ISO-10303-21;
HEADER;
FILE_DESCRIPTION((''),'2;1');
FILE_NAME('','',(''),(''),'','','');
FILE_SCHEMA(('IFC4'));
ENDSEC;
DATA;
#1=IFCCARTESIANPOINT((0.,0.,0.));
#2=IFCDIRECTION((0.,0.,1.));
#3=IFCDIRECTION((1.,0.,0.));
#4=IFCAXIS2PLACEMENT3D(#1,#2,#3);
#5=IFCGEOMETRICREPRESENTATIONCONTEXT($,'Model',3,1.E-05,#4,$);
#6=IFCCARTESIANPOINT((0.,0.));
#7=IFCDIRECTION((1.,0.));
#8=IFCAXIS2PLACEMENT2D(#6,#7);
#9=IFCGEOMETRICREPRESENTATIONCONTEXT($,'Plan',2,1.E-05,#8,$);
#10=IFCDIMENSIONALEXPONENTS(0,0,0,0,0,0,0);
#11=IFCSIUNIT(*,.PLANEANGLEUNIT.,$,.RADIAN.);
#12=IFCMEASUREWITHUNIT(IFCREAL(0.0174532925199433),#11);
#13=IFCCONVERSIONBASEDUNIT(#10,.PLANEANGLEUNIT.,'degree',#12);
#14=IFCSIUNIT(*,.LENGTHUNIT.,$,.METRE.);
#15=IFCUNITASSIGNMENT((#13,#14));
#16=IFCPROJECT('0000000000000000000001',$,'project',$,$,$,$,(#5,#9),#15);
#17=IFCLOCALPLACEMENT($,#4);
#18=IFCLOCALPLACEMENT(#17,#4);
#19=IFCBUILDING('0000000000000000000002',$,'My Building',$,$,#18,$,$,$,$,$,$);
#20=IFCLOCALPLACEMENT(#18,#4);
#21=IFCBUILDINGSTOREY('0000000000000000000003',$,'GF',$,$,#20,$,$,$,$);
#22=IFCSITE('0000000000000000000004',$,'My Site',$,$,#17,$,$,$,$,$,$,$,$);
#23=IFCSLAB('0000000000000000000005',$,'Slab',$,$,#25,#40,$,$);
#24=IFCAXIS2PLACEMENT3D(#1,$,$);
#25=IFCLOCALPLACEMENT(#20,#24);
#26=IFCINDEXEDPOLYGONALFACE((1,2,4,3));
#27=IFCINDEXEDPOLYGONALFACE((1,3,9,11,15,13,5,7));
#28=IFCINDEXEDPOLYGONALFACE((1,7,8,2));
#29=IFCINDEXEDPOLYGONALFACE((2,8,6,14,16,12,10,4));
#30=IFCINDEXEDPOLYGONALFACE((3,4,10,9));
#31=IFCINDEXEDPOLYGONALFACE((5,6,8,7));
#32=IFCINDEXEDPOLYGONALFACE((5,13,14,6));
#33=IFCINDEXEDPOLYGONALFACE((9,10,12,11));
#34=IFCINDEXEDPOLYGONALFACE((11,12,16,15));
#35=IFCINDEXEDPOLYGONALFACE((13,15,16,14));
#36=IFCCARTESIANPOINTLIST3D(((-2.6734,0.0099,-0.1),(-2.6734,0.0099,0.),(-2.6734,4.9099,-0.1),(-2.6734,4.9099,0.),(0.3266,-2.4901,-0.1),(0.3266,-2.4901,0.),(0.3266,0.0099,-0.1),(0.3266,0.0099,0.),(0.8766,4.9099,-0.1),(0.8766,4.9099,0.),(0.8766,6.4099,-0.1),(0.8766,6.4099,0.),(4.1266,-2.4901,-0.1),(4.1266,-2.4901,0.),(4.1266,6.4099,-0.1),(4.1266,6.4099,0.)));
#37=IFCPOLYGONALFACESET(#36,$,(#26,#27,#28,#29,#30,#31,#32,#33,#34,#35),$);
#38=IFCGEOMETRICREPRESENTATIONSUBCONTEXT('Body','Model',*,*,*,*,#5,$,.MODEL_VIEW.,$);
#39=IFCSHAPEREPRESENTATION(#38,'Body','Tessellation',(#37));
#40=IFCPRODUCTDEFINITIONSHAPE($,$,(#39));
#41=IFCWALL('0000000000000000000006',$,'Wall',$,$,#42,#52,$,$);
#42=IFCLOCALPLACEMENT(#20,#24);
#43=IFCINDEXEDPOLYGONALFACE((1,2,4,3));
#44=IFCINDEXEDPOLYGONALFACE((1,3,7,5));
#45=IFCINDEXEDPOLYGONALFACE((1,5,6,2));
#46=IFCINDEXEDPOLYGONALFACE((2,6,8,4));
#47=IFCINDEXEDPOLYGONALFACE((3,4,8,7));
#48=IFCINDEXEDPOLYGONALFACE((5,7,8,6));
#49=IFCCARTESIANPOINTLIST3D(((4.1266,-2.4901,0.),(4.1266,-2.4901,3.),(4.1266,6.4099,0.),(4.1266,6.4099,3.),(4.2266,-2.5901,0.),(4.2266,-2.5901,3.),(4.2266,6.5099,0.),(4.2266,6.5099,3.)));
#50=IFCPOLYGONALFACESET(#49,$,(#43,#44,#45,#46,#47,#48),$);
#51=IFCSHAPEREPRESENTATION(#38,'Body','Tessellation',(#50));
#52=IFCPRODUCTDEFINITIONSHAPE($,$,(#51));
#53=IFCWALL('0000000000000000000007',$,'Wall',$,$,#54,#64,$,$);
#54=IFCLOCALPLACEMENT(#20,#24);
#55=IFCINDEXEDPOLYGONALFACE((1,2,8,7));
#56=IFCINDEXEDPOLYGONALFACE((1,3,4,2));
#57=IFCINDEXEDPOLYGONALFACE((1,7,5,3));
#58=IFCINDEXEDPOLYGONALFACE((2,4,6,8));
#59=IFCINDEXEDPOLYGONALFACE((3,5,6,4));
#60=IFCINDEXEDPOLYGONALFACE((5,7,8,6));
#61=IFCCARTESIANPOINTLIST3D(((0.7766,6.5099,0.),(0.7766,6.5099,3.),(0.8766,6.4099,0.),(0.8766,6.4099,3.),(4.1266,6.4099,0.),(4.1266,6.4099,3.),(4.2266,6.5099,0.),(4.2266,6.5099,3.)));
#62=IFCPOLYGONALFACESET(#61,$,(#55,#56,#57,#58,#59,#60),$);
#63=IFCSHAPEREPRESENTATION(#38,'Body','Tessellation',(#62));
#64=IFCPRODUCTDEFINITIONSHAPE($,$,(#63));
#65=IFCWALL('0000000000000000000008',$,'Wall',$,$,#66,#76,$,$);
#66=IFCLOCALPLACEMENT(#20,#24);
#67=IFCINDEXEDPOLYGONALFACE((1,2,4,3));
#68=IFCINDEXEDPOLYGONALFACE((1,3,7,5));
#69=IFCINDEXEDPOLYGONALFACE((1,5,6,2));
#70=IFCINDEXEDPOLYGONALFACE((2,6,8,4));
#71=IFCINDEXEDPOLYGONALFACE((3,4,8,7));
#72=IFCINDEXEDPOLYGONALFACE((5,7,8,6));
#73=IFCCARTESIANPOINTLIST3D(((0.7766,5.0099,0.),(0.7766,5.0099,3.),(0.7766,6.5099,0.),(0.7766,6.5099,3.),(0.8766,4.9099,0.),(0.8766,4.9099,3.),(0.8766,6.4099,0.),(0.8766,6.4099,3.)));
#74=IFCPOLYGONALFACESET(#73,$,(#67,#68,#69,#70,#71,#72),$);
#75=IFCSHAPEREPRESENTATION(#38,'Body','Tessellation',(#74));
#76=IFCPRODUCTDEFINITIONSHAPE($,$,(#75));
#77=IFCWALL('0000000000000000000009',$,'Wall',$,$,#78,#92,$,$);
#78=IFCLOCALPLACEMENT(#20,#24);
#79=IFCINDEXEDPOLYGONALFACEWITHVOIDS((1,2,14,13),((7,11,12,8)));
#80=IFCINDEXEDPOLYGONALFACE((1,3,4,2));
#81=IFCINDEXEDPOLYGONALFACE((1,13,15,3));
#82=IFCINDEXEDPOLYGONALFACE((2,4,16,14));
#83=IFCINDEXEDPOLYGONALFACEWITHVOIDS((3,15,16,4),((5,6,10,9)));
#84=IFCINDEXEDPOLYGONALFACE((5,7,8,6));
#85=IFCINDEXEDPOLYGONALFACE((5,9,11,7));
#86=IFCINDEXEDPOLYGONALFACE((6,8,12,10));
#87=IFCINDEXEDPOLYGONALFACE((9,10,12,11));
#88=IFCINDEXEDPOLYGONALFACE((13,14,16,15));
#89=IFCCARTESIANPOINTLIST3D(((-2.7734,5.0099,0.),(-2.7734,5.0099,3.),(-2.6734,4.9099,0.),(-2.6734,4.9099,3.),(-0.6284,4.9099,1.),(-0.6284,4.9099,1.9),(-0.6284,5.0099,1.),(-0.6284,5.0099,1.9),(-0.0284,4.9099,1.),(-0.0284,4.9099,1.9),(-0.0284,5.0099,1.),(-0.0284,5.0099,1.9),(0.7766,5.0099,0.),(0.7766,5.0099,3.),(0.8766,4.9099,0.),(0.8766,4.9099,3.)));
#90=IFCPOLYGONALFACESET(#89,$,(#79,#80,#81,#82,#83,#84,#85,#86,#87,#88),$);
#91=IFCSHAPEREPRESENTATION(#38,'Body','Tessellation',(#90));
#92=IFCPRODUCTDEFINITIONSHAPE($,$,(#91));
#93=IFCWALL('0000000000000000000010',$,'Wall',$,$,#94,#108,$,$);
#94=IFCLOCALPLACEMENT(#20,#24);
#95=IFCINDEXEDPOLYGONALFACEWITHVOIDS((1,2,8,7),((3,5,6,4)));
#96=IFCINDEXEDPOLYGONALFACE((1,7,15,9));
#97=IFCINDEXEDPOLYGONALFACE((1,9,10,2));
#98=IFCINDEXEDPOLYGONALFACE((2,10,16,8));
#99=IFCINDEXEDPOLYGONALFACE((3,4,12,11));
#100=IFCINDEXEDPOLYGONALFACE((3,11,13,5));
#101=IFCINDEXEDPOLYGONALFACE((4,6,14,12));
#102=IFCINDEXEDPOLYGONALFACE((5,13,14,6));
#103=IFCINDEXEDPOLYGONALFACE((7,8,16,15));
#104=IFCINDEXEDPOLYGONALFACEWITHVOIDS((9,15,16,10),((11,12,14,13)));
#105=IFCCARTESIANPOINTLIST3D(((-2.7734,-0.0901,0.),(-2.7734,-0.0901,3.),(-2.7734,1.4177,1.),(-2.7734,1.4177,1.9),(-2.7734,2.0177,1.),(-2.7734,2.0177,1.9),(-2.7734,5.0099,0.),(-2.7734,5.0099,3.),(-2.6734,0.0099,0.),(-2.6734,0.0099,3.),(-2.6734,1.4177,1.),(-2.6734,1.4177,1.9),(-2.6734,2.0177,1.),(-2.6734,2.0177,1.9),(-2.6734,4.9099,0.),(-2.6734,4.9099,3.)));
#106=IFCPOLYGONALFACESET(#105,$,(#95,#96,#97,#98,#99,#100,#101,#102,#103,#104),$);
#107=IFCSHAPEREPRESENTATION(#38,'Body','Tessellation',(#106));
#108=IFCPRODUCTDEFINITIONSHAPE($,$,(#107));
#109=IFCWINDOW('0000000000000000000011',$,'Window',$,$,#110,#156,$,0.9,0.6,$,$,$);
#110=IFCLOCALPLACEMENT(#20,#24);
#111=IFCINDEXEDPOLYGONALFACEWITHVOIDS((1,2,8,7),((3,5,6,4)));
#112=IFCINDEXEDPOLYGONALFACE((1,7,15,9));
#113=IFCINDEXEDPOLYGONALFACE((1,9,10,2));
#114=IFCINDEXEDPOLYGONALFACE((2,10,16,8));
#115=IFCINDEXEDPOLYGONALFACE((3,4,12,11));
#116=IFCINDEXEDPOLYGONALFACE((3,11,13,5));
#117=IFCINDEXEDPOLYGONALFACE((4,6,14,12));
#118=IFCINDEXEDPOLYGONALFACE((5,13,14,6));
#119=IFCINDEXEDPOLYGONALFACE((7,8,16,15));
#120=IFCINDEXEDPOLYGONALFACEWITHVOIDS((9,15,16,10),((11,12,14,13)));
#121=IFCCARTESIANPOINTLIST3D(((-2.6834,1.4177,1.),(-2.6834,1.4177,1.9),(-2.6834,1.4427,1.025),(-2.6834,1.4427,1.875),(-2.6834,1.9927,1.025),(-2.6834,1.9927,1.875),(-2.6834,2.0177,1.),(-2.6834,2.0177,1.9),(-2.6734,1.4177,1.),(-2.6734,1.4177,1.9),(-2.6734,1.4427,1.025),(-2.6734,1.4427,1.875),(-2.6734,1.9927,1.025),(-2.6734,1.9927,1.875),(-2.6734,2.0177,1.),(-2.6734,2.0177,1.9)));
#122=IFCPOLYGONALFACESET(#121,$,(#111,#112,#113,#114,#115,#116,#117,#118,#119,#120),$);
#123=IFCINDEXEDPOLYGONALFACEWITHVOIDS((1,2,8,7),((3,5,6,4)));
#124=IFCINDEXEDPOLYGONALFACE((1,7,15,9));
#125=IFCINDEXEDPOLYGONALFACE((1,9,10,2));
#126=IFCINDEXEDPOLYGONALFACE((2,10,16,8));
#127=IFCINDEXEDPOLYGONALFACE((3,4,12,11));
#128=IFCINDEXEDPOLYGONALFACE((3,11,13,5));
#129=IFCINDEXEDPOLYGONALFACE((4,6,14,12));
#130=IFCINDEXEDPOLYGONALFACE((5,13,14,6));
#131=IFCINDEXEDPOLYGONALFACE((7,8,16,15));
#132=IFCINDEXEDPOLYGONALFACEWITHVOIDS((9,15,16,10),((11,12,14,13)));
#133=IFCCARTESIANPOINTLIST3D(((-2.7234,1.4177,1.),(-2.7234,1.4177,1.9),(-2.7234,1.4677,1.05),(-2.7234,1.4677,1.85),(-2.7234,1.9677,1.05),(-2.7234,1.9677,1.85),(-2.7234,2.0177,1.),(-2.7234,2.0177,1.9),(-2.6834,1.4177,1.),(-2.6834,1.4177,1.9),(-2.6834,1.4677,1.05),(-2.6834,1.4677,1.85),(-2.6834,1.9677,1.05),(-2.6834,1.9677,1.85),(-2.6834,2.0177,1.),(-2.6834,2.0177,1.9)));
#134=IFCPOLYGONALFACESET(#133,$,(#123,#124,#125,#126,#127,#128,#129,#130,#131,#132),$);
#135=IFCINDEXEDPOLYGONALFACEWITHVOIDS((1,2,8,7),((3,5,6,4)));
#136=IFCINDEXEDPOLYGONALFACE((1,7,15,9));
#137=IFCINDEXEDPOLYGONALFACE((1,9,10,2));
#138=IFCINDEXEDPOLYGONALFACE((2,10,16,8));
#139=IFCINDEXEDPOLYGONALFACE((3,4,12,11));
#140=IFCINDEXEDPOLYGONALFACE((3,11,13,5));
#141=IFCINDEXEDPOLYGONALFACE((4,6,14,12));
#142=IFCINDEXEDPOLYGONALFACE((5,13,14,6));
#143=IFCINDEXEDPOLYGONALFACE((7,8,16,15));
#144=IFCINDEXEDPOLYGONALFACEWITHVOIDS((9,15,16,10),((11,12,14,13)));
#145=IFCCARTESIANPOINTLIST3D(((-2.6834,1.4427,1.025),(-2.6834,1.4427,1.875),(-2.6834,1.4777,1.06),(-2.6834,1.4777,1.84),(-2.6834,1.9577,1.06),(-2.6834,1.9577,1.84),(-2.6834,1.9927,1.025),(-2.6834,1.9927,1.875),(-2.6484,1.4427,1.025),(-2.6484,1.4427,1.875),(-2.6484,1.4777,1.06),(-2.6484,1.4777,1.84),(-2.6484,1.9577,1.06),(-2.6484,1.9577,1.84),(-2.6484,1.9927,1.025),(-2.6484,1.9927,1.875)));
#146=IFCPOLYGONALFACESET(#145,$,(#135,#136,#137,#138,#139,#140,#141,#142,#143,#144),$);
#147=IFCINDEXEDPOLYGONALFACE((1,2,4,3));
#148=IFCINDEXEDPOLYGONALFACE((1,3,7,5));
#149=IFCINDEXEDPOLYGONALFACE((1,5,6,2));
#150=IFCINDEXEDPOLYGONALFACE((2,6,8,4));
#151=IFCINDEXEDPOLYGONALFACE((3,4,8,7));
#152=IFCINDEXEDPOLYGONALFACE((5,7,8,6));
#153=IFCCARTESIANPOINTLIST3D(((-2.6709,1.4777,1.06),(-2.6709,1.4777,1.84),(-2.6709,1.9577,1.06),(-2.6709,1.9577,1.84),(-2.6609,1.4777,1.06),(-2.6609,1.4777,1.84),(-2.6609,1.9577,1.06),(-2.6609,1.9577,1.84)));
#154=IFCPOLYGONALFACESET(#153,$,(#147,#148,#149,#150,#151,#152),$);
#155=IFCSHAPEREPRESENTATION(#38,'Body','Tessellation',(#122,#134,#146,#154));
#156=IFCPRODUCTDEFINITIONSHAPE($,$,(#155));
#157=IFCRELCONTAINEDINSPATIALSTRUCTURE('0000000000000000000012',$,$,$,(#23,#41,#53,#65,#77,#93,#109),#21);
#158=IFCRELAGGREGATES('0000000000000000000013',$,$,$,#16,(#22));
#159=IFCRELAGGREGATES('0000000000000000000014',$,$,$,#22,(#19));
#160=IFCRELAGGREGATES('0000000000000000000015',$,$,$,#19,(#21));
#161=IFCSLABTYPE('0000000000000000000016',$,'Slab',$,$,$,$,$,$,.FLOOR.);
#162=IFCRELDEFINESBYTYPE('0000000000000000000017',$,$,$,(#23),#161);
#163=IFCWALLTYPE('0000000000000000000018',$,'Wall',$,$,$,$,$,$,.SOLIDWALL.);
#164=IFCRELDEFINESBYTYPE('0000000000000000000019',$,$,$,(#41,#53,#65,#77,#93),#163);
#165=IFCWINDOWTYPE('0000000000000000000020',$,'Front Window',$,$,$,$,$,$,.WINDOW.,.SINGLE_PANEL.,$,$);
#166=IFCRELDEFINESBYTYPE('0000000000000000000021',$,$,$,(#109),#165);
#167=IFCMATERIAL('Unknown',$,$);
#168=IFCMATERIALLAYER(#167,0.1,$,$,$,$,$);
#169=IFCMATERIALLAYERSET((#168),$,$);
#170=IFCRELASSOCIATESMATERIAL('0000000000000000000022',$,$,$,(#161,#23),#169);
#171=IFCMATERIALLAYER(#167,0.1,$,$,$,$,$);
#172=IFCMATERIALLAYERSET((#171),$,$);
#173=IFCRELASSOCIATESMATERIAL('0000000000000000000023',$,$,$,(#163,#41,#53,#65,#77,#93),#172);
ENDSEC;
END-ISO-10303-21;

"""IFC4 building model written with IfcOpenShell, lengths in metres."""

from ifc_helpers import new_model, entity, si_unit, converted_unit, frame, origin_with_axes, origin_2d_with_axis, place, context, subcontext, project, spatial, line, indexed_curve, outline, extrude, shape, source, transform, mapped, material, layer, layer_set, layer_usage, type_object, type_shapes, element, fill, save


model = new_model("IFC4")

# Units and contexts
model_context = context("Model", 3, precision=1e-05, world=origin_with_axes())
plan_context = context("Plan", 2, precision=1e-05, world=origin_2d_with_axis())
body_context_1 = subcontext(model_context, "Body", "Model", "MODEL_VIEW")
body_context_2 = subcontext(plan_context, "Body", "Plan", "PLAN_VIEW")
ifc_project = project(units=[converted_unit("PLANEANGLEUNIT", "degree", entity("IfcReal", 0.0174532925199433), si_unit("PLANEANGLEUNIT", "RADIAN"), dimensions=[0, 0, 0, 0, 0, 0, 0]), si_unit("LENGTHUNIT", "METRE")], contexts=[model_context, plan_context])

# Site, building, storey
site_placement = place(None, origin_with_axes())
site = spatial("IfcSite", under=ifc_project, at=site_placement, Name="My Site")
building_placement = place(site_placement, origin_with_axes())
building = spatial("IfcBuilding", under=site, at=building_placement, Name="My Building")
storey_placement = place(building_placement, origin_with_axes())
storey = spatial("IfcBuildingStorey", under=building, at=storey_placement, Name="GF")

# Slab
ifc_material = material(Name="Unknown")
ifc_layer_1 = layer(ifc_material, 0.1)
ifc_layer_set_1 = layer_set([ifc_layer_1])
ifc_layer_usage_1 = layer_usage(ifc_layer_set_1, "AXIS3", "POSITIVE", -0.1)
slab_type = type_object("IfcSlabType", Name="Slab", PredefinedType="FLOOR", material=ifc_layer_set_1)
slab_placement = place(storey_placement, frame((4.1266, 6.4099, 0.0), z_axis=(0.0, 0.0, 1.0), x_axis=(1.0, 0.0, 0.0)))
element("IfcSlab", 1, at=slab_placement, inside=storey, type_object=slab_type, material=ifc_layer_usage_1, Name="Slab", context=body_context_1, shape_type="SweptSolid", body=[
    extrude(outline(indexed_curve([(0.0, 0.0), (-3.25, 0.0), (-3.25, -1.5), (-6.8, -1.5), (-6.8, -6.4), (-3.8, -6.4), (-3.8, -8.9), (0.0, -8.9), (0.0, 0.0)])), frame((0.0, 0.0, -0.1), z_axis=(0.0, 0.0, 1.0), x_axis=(1.0, 0.0, 0.0)), (0.0, 0.0, 1.0), 0.1),
])

# Shared definitions
ifc_layer_2 = layer(ifc_material, 0.1)
ifc_layer_set_2 = layer_set([ifc_layer_2])
wall_type = type_object("IfcWallType", Name="Wall", PredefinedType="SOLIDWALL", material=ifc_layer_set_2)
shared_shape_1 = source(origin_with_axes(), body_context_1, "Body", "SweptSolid", [
    extrude(outline(indexed_curve([(0.0, 0.0), (0.6, 0.0), (0.6, 0.9), (0.0, 0.9)], segments=[line(1, 2, 3, 4, 1)])), frame((0.0, -0.6, 0.0), z_axis=(0.0, -1.0, 0.0), x_axis=(1.0, 0.0, 0.0)), (0.0, 0.0, -1.0), 1.2),
])
window_type_1 = type_object("IfcWindowType", Name="Front Window", PartitioningType="SINGLE_PANEL", PredefinedType="WINDOW")
shared_shape_2 = source(origin_with_axes(), body_context_1, "Body", "SweptSolid", [
    extrude(outline(indexed_curve([(0.0, 0.0), (0.6, 0.0), (0.6, 0.9), (0.0, 0.9)], segments=[line(1, 2, 3, 4, 1)]), holes=[indexed_curve([(0.025, 0.025), (0.575, 0.025), (0.575, 0.875), (0.025, 0.875)], segments=[line(1, 2, 3, 4, 1)])]), frame((0.0, 0.09, 0.0), z_axis=(0.0, -1.0, 0.0), x_axis=(1.0, 0.0, 0.0)), (0.0, 0.0, -1.0), 0.01),
    extrude(outline(indexed_curve([(0.0, 0.0), (0.6, 0.0), (0.6, 0.9), (0.0, 0.9)], segments=[line(1, 2, 3, 4, 1)]), holes=[indexed_curve([(0.05, 0.05), (0.55, 0.05), (0.55, 0.85), (0.05, 0.85)], segments=[line(1, 2, 3, 4, 1)])]), frame((0.0, 0.05, 0.0), z_axis=(0.0, -1.0, 0.0), x_axis=(1.0, 0.0, 0.0)), (0.0, 0.0, -1.0), 0.04),
    extrude(outline(indexed_curve([(0.0, 0.0), (0.55, 0.0), (0.55, 0.85), (0.0, 0.85)], segments=[line(1, 2, 3, 4, 1)]), holes=[indexed_curve([(0.035, 0.035), (0.515, 0.035), (0.515, 0.815), (0.035, 0.815)], segments=[line(1, 2, 3, 4, 1)])]), frame((0.025, 0.09, 0.025), z_axis=(0.0, -1.0, 0.0), x_axis=(1.0, 0.0, 0.0)), (0.0, 0.0, -1.0), 0.035),
    extrude(outline(indexed_curve([(0.035, 0.035), (0.515, 0.035), (0.515, 0.815), (0.035, 0.815)], segments=[line(1, 2, 3, 4, 1)])), frame((0.025, 0.1025, 0.025), z_axis=(0.0, -1.0, 0.0), x_axis=(1.0, 0.0, 0.0)), (0.0, 0.0, -1.0), 0.01),
])
shared_shape_3 = source(origin_with_axes(), body_context_2, "Body", "Curve2D", [
    entity("IfcIndexedPolyCurve", entity("IfcCartesianPointList2D", [[0.05, 0.05], [0.55, 0.05]])),
    entity("IfcIndexedPolyCurve", entity("IfcCartesianPointList2D", [[0.0, 0.1], [0.025, 0.1], [0.025, 0.09], [0.05, 0.09], [0.05, 0.05], [0.0, 0.05]]), [entity("IfcLineIndex", [1, 2, 3, 4, 5, 6, 1])]),
    entity("IfcIndexedPolyCurve", entity("IfcCartesianPointList2D", [[0.6, 0.1], [0.575, 0.1], [0.575, 0.09], [0.55, 0.09], [0.55, 0.05], [0.6, 0.05]]), [entity("IfcLineIndex", [1, 2, 3, 4, 5, 6, 1])]),
    entity("IfcIndexedPolyCurve", entity("IfcCartesianPointList2D", [[0.025, 0.09], [0.06, 0.09], [0.06, 0.125], [0.025, 0.125]]), [entity("IfcLineIndex", [1, 2, 3, 4, 1])]),
    entity("IfcIndexedPolyCurve", entity("IfcCartesianPointList2D", [[0.575, 0.09], [0.54, 0.09], [0.54, 0.125], [0.575, 0.125]]), [entity("IfcLineIndex", [1, 2, 3, 4, 1])]),
    entity("IfcIndexedPolyCurve", entity("IfcCartesianPointList2D", [[0.06, 0.09], [0.54, 0.09]])),
    entity("IfcIndexedPolyCurve", entity("IfcCartesianPointList2D", [[0.06, 0.125], [0.54, 0.125]])),
    entity("IfcIndexedPolyCurve", entity("IfcCartesianPointList2D", [[0.06, 0.1075], [0.54, 0.1075]])),
])
type_shapes(window_type_1, [shared_shape_2, shared_shape_3])

# Walls
ifc_layer_usage_2 = layer_usage(ifc_layer_set_2, "AXIS2", "POSITIVE", 0.0)
wall_1_placement = place(storey_placement, frame((4.2266, -2.5901, 0.0), z_axis=(0.0, 0.0, 1.0), x_axis=(0.0, 1.0, 0.0)))
element("IfcWall", 2, at=wall_1_placement, inside=storey, type_object=wall_type, material=ifc_layer_usage_2, Name="Wall", context=body_context_1, shape_type="SweptSolid", body=[
    extrude(outline(indexed_curve([(0.0, 0.0), (0.1, 0.1), (9.0, 0.1), (9.1, 0.0)], segments=[line(1, 2, 3, 4, 1)])), origin_with_axes(), (0.0, 0.0, 1.0), 3.0),
])
ifc_layer_usage_3 = layer_usage(ifc_layer_set_2, "AXIS2", "POSITIVE", 0.0)
wall_2_placement = place(storey_placement, frame((4.2266, 6.5099, 0.0), z_axis=(0.0, 0.0, 1.0), x_axis=(-1.0, 0.0, 0.0)))
element("IfcWall", 3, at=wall_2_placement, inside=storey, type_object=wall_type, material=ifc_layer_usage_3, Name="Wall", context=body_context_1, shape_type="SweptSolid", body=[
    extrude(outline(indexed_curve([(0.0, 0.0), (0.1, 0.1), (3.35, 0.1), (3.45, 0.0)], segments=[line(1, 2, 3, 4, 1)])), origin_with_axes(), (0.0, 0.0, 1.0), 3.0),
])
ifc_layer_usage_4 = layer_usage(ifc_layer_set_2, "AXIS2", "POSITIVE", 0.0)
wall_3_placement = place(storey_placement, frame((0.7766, 6.5099, 0.0), z_axis=(0.0, 0.0, 1.0), x_axis=(0.0, -1.0, 0.0)))
element("IfcWall", 4, at=wall_3_placement, inside=storey, type_object=wall_type, material=ifc_layer_usage_4, Name="Wall", context=body_context_1, shape_type="SweptSolid", body=[
    extrude(outline(indexed_curve([(0.0, 0.0), (0.1, 0.1), (1.6, 0.1), (1.5, 0.0)], segments=[line(1, 2, 3, 4, 1)])), origin_with_axes(), (0.0, 0.0, 1.0), 3.0),
])

# Wall, opening
ifc_layer_usage_5 = layer_usage(ifc_layer_set_2, "AXIS2", "POSITIVE", 0.0)
wall_4_placement = place(storey_placement, frame((0.7766, 5.0099, 0.0), z_axis=(0.0, 0.0, 1.0), x_axis=(-1.0, 0.0, 0.0)))
wall_4 = element("IfcWall", 5, at=wall_4_placement, inside=storey, type_object=wall_type, material=ifc_layer_usage_5, Name="Wall", context=body_context_1, shape_type="SweptSolid", body=[
    extrude(outline(indexed_curve([(0.0, 0.0), (-0.1, 0.1), (3.45, 0.1), (3.55, 0.0)], segments=[line(1, 2, 3, 4, 1)])), origin_with_axes(), (0.0, 0.0, 1.0), 3.0),
])
shared_shape_4 = source(origin_with_axes(), body_context_1, "Body", "SweptSolid", [
    extrude(outline(indexed_curve([(0.0, 0.0), (0.6, 0.0), (0.6, 0.9), (0.0, 0.9)], segments=[line(1, 2, 3, 4, 1)])), frame((0.0, -0.6, 0.0), z_axis=(0.0, -1.0, 0.0), x_axis=(1.0, 0.0, 0.0)), (0.0, 0.0, -1.0), 1.2),
])
opening_1_placement = place(wall_4_placement, frame((0.805, 0.0, 1.0), z_axis=(0.0, 0.0, 1.0), x_axis=(1.0, 0.0, 0.0)))
element("IfcOpeningElement", 6, at=opening_1_placement, cuts=wall_4, PredefinedType="OPENING", context=body_context_1, shape_type="MappedRepresentation", body=[
    mapped(shared_shape_4, transform((0.0, 0.0, 0.0), x_axis=(1.0, 0.0, 0.0), y_axis=(0.0, 1.0, 0.0), z_axis=(0.0, 0.0, 1.0), scale=1.0)),
])

# Wall, opening, window
ifc_layer_usage_6 = layer_usage(ifc_layer_set_2, "AXIS2", "POSITIVE", 0.0)
wall_5_placement = place(storey_placement, frame((-2.7734, 5.0099, 0.0), z_axis=(0.0, 0.0, 1.0), x_axis=(0.0, -1.0, 0.0)))
wall_5 = element("IfcWall", 7, at=wall_5_placement, inside=storey, type_object=wall_type, material=ifc_layer_usage_6, Name="Wall", context=body_context_1, shape_type="SweptSolid", body=[
    extrude(outline(indexed_curve([(0.0, 0.0), (0.1, 0.1), (5.0, 0.1), (5.1, 0.0)], segments=[line(1, 2, 3, 4, 1)])), origin_with_axes(), (0.0, 0.0, 1.0), 3.0),
])
opening_2_placement = place(wall_5_placement, frame((2.9922, 0.0, 1.0), z_axis=(0.0, 0.0, 1.0), x_axis=(1.0, 0.0, 0.0)))
opening_2 = element("IfcOpeningElement", 8, at=opening_2_placement, cuts=wall_5, PredefinedType="OPENING", context=body_context_1, shape_type="MappedRepresentation", body=[
    mapped(shared_shape_1, transform((0.0, 0.0, 0.0), x_axis=(1.0, 0.0, 0.0), y_axis=(0.0, 1.0, 0.0), z_axis=(0.0, 0.0, 1.0), scale=1.0)),
])
window_1_placement = place(opening_2_placement, frame((0.0, 0.0, 0.0), z_axis=(0.0, 0.0, 1.0), x_axis=(1.0, 0.0, 0.0)))
window_1 = element("IfcWindow", 9, at=window_1_placement, inside=storey, type_object=window_type_1, Name="Window", OverallHeight=0.9, OverallWidth=0.6, shapes=[
    shape(body_context_1, "Body", "MappedRepresentation", [mapped(shared_shape_2, transform((0.0, 0.0, 0.0), x_axis=(1.0, 0.0, 0.0), y_axis=(0.0, 1.0, 0.0), z_axis=(0.0, 0.0, 1.0), scale=1.0))]),
    shape(body_context_2, "Body", "MappedRepresentation", [mapped(shared_shape_3, transform((0.0, 0.0, 0.0), x_axis=(1.0, 0.0, 0.0), y_axis=(0.0, 1.0, 0.0), z_axis=(0.0, 0.0, 1.0), scale=1.0))]),
])
fill(opening_2, window_1)

save(model, "model.ifc")
